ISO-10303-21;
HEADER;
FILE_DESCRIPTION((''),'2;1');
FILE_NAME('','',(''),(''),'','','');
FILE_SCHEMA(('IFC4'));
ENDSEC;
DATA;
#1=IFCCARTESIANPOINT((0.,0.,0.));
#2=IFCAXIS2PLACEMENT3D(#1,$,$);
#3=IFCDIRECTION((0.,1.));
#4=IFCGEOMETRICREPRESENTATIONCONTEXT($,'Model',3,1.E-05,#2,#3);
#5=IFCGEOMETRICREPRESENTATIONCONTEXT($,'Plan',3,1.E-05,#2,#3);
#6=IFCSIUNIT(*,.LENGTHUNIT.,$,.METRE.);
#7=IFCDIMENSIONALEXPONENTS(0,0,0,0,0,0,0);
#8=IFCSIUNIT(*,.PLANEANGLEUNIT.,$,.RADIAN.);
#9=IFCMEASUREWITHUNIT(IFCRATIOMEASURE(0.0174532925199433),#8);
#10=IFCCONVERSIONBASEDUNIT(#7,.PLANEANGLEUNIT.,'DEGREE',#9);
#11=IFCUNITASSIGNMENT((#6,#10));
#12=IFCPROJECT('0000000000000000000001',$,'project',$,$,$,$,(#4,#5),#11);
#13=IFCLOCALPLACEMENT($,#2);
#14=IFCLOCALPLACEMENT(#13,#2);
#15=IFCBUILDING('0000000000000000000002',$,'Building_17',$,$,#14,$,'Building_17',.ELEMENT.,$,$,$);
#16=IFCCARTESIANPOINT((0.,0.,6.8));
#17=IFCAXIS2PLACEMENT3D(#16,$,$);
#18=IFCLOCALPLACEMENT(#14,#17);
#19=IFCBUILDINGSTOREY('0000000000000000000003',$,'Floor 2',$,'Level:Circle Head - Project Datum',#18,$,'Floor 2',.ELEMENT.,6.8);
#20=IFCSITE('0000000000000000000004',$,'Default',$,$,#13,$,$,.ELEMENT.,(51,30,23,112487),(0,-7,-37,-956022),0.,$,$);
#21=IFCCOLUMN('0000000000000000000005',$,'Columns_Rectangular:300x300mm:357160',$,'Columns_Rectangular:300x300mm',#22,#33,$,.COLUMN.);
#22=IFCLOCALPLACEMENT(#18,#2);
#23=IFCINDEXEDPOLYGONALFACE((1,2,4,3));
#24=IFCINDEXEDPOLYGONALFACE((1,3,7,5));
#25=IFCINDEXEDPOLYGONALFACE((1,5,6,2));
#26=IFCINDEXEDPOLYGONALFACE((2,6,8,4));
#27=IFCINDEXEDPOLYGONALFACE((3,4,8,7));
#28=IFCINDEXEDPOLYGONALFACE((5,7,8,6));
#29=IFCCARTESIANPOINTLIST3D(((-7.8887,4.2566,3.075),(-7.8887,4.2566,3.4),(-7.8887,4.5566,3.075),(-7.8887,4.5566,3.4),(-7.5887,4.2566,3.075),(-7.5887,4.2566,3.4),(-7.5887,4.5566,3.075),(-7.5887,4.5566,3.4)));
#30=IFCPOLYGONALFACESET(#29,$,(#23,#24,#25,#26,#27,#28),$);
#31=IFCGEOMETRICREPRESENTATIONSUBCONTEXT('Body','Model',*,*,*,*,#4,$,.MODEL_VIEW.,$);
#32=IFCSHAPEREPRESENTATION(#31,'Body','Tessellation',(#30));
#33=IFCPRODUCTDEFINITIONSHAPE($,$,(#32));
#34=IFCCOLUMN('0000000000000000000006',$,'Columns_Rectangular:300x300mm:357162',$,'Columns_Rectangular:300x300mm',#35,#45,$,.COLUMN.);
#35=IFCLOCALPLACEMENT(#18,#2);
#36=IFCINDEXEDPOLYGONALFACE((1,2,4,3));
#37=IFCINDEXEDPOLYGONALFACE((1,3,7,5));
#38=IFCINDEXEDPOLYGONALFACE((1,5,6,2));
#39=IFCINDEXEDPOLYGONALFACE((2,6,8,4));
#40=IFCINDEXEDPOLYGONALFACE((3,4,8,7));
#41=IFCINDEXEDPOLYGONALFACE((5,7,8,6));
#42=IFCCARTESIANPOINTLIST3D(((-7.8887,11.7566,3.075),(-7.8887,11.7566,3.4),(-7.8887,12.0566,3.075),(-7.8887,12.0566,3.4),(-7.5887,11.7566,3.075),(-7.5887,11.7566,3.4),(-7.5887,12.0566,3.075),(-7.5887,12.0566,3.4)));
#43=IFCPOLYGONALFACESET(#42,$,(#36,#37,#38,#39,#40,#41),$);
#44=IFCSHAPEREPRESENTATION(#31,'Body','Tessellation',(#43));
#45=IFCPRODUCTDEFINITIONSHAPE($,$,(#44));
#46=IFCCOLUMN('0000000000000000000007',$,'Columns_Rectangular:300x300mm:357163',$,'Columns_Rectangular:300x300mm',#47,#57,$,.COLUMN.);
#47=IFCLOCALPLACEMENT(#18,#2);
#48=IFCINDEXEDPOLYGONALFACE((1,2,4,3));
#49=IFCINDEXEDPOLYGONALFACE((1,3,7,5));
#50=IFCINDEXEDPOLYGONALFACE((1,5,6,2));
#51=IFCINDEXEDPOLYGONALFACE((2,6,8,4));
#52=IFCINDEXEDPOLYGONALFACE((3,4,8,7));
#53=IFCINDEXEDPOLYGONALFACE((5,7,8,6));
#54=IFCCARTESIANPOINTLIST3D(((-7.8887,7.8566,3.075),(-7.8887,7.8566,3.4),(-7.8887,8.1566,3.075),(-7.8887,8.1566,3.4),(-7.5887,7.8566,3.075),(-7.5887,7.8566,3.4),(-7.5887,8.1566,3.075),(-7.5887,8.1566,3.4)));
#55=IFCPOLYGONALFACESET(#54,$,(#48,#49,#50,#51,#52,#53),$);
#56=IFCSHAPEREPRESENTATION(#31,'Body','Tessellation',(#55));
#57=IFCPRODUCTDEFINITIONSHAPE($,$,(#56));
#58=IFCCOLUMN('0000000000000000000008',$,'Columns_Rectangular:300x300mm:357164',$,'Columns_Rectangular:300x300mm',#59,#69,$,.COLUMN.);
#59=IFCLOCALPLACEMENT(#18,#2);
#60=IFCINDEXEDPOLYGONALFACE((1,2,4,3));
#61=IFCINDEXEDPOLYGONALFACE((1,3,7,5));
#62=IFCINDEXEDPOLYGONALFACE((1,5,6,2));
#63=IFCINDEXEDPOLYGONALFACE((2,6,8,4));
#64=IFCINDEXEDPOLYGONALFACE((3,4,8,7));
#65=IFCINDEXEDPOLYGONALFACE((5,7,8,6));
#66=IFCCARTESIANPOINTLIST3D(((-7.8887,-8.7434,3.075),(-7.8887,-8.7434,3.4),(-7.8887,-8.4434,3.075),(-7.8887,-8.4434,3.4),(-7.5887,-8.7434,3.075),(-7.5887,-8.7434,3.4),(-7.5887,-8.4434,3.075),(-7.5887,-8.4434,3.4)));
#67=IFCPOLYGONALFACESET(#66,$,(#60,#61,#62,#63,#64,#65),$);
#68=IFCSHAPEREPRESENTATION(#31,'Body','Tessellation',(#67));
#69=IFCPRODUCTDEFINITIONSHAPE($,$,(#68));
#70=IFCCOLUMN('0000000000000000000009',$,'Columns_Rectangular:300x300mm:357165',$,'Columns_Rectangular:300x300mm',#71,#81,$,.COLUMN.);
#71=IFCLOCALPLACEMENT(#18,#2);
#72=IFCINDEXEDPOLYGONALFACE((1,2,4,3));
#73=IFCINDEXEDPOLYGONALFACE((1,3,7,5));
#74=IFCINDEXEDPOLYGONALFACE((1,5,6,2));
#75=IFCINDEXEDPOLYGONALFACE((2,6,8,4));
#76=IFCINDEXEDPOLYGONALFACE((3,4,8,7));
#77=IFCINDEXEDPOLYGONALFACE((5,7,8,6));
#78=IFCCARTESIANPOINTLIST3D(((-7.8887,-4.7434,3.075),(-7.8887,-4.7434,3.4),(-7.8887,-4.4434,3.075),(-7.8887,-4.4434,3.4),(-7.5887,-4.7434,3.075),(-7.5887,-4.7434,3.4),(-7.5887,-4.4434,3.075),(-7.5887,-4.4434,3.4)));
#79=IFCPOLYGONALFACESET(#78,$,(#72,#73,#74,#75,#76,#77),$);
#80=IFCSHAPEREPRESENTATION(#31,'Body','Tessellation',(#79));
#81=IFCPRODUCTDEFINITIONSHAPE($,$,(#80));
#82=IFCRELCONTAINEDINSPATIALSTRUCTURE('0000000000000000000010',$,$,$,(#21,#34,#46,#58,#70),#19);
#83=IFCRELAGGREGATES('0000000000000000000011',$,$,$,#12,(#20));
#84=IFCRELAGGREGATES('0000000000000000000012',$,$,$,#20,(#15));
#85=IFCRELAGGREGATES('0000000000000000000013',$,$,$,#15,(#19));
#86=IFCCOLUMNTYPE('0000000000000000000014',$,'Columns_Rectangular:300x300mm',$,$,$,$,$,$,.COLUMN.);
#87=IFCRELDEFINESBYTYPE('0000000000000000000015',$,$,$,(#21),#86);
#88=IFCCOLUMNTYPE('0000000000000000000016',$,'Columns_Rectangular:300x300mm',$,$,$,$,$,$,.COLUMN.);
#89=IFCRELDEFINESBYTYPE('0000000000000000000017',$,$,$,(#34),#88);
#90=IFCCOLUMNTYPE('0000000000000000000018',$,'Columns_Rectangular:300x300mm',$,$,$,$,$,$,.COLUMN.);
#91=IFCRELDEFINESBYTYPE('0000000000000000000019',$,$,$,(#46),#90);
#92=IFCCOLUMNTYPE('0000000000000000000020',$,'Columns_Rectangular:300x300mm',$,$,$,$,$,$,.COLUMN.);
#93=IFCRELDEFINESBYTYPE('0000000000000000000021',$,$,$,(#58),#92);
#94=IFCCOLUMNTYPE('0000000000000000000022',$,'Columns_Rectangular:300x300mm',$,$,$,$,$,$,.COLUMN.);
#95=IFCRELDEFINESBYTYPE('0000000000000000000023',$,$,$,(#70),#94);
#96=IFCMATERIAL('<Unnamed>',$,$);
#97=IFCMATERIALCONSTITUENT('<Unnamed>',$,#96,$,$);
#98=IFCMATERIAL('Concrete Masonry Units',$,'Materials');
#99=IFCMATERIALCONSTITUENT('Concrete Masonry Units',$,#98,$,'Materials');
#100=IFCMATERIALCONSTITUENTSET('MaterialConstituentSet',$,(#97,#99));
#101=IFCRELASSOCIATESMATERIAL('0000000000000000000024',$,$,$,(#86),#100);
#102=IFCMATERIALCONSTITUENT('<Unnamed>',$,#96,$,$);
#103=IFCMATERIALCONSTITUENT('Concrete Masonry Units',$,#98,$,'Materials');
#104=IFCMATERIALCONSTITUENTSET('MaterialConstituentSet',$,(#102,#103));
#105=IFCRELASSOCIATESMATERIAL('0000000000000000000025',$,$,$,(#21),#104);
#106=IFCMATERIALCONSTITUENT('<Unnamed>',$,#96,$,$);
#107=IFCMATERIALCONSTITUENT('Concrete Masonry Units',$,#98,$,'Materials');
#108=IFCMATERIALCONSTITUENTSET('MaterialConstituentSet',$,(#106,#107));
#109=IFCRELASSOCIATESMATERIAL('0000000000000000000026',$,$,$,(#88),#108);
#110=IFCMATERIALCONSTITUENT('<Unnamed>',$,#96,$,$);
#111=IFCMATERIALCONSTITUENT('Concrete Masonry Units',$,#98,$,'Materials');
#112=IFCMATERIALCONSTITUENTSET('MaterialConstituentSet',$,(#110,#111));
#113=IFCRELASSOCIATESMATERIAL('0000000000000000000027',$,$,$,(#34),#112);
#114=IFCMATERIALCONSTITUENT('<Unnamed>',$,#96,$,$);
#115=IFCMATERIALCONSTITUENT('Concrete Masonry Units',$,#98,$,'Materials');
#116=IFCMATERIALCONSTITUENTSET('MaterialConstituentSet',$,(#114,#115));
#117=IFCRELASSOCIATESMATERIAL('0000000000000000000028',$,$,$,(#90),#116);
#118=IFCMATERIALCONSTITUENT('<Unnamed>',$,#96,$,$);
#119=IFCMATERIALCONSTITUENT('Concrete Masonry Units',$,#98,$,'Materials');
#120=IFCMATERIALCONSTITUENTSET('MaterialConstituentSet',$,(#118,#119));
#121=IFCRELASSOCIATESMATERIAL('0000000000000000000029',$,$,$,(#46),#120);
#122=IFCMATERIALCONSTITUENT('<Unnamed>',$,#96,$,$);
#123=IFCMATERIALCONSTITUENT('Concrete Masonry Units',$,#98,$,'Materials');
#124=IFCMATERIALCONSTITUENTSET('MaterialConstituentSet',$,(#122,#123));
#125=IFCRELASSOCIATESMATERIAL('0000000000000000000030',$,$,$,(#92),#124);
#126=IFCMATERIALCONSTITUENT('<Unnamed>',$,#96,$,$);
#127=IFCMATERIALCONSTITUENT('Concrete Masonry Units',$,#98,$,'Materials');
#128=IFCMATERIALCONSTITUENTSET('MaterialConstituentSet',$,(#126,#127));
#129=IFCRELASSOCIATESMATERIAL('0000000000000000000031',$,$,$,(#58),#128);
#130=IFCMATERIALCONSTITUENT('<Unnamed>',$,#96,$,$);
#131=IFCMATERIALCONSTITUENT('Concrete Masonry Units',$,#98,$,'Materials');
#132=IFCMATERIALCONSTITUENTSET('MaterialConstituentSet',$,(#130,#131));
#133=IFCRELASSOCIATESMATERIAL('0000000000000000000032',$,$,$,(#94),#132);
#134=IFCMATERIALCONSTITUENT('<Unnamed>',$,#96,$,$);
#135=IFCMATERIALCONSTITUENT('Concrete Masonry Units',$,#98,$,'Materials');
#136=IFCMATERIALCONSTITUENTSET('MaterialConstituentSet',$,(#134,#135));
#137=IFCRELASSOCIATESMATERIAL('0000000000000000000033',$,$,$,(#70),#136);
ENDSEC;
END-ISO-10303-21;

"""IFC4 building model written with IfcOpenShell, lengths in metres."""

from ifc_helpers import new_model, entity, si_unit, converted_unit, direction, frame, origin, place, context, subcontext, project, spatial, indexed_curve, outline, extrude, source, transform, mapped, material, constituent, constituent_set, type_object, type_shapes, element, save


model = new_model("IFC4")

# Units and contexts
model_context = context("Model", 3, precision=1e-05, world=origin(), true_north=direction((0.0, 1.0)))
plan_context = context("Plan", 3, precision=1e-05, world=origin(), true_north=direction((0.0, 1.0)))
body_context = subcontext(model_context, "Body", "Model", "MODEL_VIEW")
ifc_project = project(units=[si_unit("LENGTHUNIT", "METRE"), converted_unit("PLANEANGLEUNIT", "DEGREE", entity("IfcRatioMeasure", 0.0174532925199433), si_unit("PLANEANGLEUNIT", "RADIAN"), dimensions=[0, 0, 0, 0, 0, 0, 0])], contexts=[model_context, plan_context])

# Site, building, storey
site_placement = place(None, origin())
site = spatial("IfcSite", under=ifc_project, at=site_placement, Name="Default", CompositionType="ELEMENT", RefLatitude=(51, 30, 23, 112487), RefLongitude=(0, -7, -37, -956022), RefElevation=0.0)
building_placement = place(site_placement, origin())
building = spatial("IfcBuilding", under=site, at=building_placement, Name="Building_17", LongName="Building_17", CompositionType="ELEMENT")
storey_placement = place(building_placement, frame((0.0, 0.0, 6.8)))
storey = spatial("IfcBuildingStorey", under=building, at=storey_placement, Name="Floor 2", ObjectType="Level:Circle Head - Project Datum", LongName="Floor 2", CompositionType="ELEMENT", Elevation=6.8)

# Columns
ifc_material_1 = material(Name="<Unnamed>")
ifc_material_2 = material(Name="Concrete Masonry Units", Category="Materials")
ifc_constituent_1 = constituent(ifc_material_1, Name="<Unnamed>")
ifc_constituent_2 = constituent(ifc_material_2, Name="Concrete Masonry Units", Category="Materials")
ifc_constituent_set_1 = constituent_set(constituents=[ifc_constituent_1, ifc_constituent_2], Name="MaterialConstituentSet")
ifc_constituent_3 = constituent(ifc_material_1, Name="<Unnamed>")
ifc_constituent_4 = constituent(ifc_material_2, Name="Concrete Masonry Units", Category="Materials")
ifc_constituent_set_2 = constituent_set(constituents=[ifc_constituent_3, ifc_constituent_4], Name="MaterialConstituentSet")
column_type_1 = type_object("IfcColumnType", Name="Columns_Rectangular:300x300mm", PredefinedType="COLUMN", material=ifc_constituent_set_2)
shared_shape_1 = source(origin(), body_context, "Body", "SweptSolid", [
    extrude(outline(indexed_curve([(-0.15, -0.15), (0.15, -0.15), (0.15, 0.15), (-0.15, 0.15), (-0.15, -0.15)], self_intersect=False)), frame((-7.7387, 4.4066, 9.875), z_axis=(0.0, 0.0, 1.0), x_axis=(0.0, -1.0, 0.0)), (0.0, 0.0, 1.0), 0.325),
])
type_shapes(column_type_1, [shared_shape_1])
column_1_placement = place(storey_placement, frame((0.0, 0.0, -6.8)))
element("IfcColumn", 1, at=column_1_placement, inside=storey, type_object=column_type_1, material=ifc_constituent_set_1, Name="Columns_Rectangular:300x300mm:357160", ObjectType="Columns_Rectangular:300x300mm", PredefinedType="COLUMN", context=body_context, shape_type="MappedRepresentation", body=[
    mapped(shared_shape_1, transform((0.0, 0.0, 0.0), scale=1.0)),
])
ifc_constituent_5 = constituent(ifc_material_1, Name="<Unnamed>")
ifc_constituent_6 = constituent(ifc_material_2, Name="Concrete Masonry Units", Category="Materials")
ifc_constituent_set_3 = constituent_set(constituents=[ifc_constituent_5, ifc_constituent_6], Name="MaterialConstituentSet")
ifc_constituent_7 = constituent(ifc_material_1, Name="<Unnamed>")
ifc_constituent_8 = constituent(ifc_material_2, Name="Concrete Masonry Units", Category="Materials")
ifc_constituent_set_4 = constituent_set(constituents=[ifc_constituent_7, ifc_constituent_8], Name="MaterialConstituentSet")
column_type_2 = type_object("IfcColumnType", Name="Columns_Rectangular:300x300mm", PredefinedType="COLUMN", material=ifc_constituent_set_4)
shared_shape_2 = source(origin(), body_context, "Body", "SweptSolid", [
    extrude(outline(indexed_curve([(-0.15, -0.15), (0.15, -0.15), (0.15, 0.15), (-0.15, 0.15), (-0.15, -0.15)], self_intersect=False)), frame((-7.7387, 11.9066, 9.875), z_axis=(0.0, 0.0, 1.0), x_axis=(0.0, -1.0, 0.0)), (0.0, 0.0, 1.0), 0.325),
])
type_shapes(column_type_2, [shared_shape_2])
column_2_placement = place(storey_placement, frame((0.0, 0.0, -6.8)))
element("IfcColumn", 2, at=column_2_placement, inside=storey, type_object=column_type_2, material=ifc_constituent_set_3, Name="Columns_Rectangular:300x300mm:357162", ObjectType="Columns_Rectangular:300x300mm", PredefinedType="COLUMN", context=body_context, shape_type="MappedRepresentation", body=[
    mapped(shared_shape_2, transform((0.0, 0.0, 0.0), scale=1.0)),
])
ifc_constituent_9 = constituent(ifc_material_1, Name="<Unnamed>")
ifc_constituent_10 = constituent(ifc_material_2, Name="Concrete Masonry Units", Category="Materials")
ifc_constituent_set_5 = constituent_set(constituents=[ifc_constituent_9, ifc_constituent_10], Name="MaterialConstituentSet")
ifc_constituent_11 = constituent(ifc_material_1, Name="<Unnamed>")
ifc_constituent_12 = constituent(ifc_material_2, Name="Concrete Masonry Units", Category="Materials")
ifc_constituent_set_6 = constituent_set(constituents=[ifc_constituent_11, ifc_constituent_12], Name="MaterialConstituentSet")
column_type_3 = type_object("IfcColumnType", Name="Columns_Rectangular:300x300mm", PredefinedType="COLUMN", material=ifc_constituent_set_6)
shared_shape_3 = source(origin(), body_context, "Body", "SweptSolid", [
    extrude(outline(indexed_curve([(-0.15, -0.15), (0.15, -0.15), (0.15, 0.15), (-0.15, 0.15), (-0.15, -0.15)], self_intersect=False)), frame((-7.7387, 8.0066, 9.875), z_axis=(0.0, 0.0, 1.0), x_axis=(0.0, -1.0, 0.0)), (0.0, 0.0, 1.0), 0.325),
])
type_shapes(column_type_3, [shared_shape_3])
column_3_placement = place(storey_placement, frame((0.0, 0.0, -6.8)))
element("IfcColumn", 3, at=column_3_placement, inside=storey, type_object=column_type_3, material=ifc_constituent_set_5, Name="Columns_Rectangular:300x300mm:357163", ObjectType="Columns_Rectangular:300x300mm", PredefinedType="COLUMN", context=body_context, shape_type="MappedRepresentation", body=[
    mapped(shared_shape_3, transform((0.0, 0.0, 0.0), scale=1.0)),
])
ifc_constituent_13 = constituent(ifc_material_1, Name="<Unnamed>")
ifc_constituent_14 = constituent(ifc_material_2, Name="Concrete Masonry Units", Category="Materials")
ifc_constituent_set_7 = constituent_set(constituents=[ifc_constituent_13, ifc_constituent_14], Name="MaterialConstituentSet")
ifc_constituent_15 = constituent(ifc_material_1, Name="<Unnamed>")
ifc_constituent_16 = constituent(ifc_material_2, Name="Concrete Masonry Units", Category="Materials")
ifc_constituent_set_8 = constituent_set(constituents=[ifc_constituent_15, ifc_constituent_16], Name="MaterialConstituentSet")
column_type_4 = type_object("IfcColumnType", Name="Columns_Rectangular:300x300mm", PredefinedType="COLUMN", material=ifc_constituent_set_8)
shared_shape_4 = source(origin(), body_context, "Body", "SweptSolid", [
    extrude(outline(indexed_curve([(-0.15, -0.15), (0.15, -0.15), (0.15, 0.15), (-0.15, 0.15), (-0.15, -0.15)], self_intersect=False)), frame((-7.7387, -8.5934, 9.875), z_axis=(0.0, 0.0, 1.0), x_axis=(0.0, -1.0, 0.0)), (0.0, 0.0, 1.0), 0.325),
])
type_shapes(column_type_4, [shared_shape_4])
column_4_placement = place(storey_placement, frame((0.0, 0.0, -6.8)))
element("IfcColumn", 4, at=column_4_placement, inside=storey, type_object=column_type_4, material=ifc_constituent_set_7, Name="Columns_Rectangular:300x300mm:357164", ObjectType="Columns_Rectangular:300x300mm", PredefinedType="COLUMN", context=body_context, shape_type="MappedRepresentation", body=[
    mapped(shared_shape_4, transform((0.0, 0.0, 0.0), scale=1.0)),
])
ifc_constituent_17 = constituent(ifc_material_1, Name="<Unnamed>")
ifc_constituent_18 = constituent(ifc_material_2, Name="Concrete Masonry Units", Category="Materials")
ifc_constituent_set_9 = constituent_set(constituents=[ifc_constituent_17, ifc_constituent_18], Name="MaterialConstituentSet")
ifc_constituent_19 = constituent(ifc_material_1, Name="<Unnamed>")
ifc_constituent_20 = constituent(ifc_material_2, Name="Concrete Masonry Units", Category="Materials")
ifc_constituent_set_10 = constituent_set(constituents=[ifc_constituent_19, ifc_constituent_20], Name="MaterialConstituentSet")
column_type_5 = type_object("IfcColumnType", Name="Columns_Rectangular:300x300mm", PredefinedType="COLUMN", material=ifc_constituent_set_10)
shared_shape_5 = source(origin(), body_context, "Body", "SweptSolid", [
    extrude(outline(indexed_curve([(-0.15, -0.15), (0.15, -0.15), (0.15, 0.15), (-0.15, 0.15), (-0.15, -0.15)], self_intersect=False)), frame((-7.7387, -4.5934, 9.875), z_axis=(0.0, 0.0, 1.0), x_axis=(0.0, -1.0, 0.0)), (0.0, 0.0, 1.0), 0.325),
])
type_shapes(column_type_5, [shared_shape_5])
column_5_placement = place(storey_placement, frame((0.0, 0.0, -6.8)))
element("IfcColumn", 5, at=column_5_placement, inside=storey, type_object=column_type_5, material=ifc_constituent_set_9, Name="Columns_Rectangular:300x300mm:357165", ObjectType="Columns_Rectangular:300x300mm", PredefinedType="COLUMN", context=body_context, shape_type="MappedRepresentation", body=[
    mapped(shared_shape_5, transform((0.0, 0.0, 0.0), scale=1.0)),
])

save(model, "model.ifc")
